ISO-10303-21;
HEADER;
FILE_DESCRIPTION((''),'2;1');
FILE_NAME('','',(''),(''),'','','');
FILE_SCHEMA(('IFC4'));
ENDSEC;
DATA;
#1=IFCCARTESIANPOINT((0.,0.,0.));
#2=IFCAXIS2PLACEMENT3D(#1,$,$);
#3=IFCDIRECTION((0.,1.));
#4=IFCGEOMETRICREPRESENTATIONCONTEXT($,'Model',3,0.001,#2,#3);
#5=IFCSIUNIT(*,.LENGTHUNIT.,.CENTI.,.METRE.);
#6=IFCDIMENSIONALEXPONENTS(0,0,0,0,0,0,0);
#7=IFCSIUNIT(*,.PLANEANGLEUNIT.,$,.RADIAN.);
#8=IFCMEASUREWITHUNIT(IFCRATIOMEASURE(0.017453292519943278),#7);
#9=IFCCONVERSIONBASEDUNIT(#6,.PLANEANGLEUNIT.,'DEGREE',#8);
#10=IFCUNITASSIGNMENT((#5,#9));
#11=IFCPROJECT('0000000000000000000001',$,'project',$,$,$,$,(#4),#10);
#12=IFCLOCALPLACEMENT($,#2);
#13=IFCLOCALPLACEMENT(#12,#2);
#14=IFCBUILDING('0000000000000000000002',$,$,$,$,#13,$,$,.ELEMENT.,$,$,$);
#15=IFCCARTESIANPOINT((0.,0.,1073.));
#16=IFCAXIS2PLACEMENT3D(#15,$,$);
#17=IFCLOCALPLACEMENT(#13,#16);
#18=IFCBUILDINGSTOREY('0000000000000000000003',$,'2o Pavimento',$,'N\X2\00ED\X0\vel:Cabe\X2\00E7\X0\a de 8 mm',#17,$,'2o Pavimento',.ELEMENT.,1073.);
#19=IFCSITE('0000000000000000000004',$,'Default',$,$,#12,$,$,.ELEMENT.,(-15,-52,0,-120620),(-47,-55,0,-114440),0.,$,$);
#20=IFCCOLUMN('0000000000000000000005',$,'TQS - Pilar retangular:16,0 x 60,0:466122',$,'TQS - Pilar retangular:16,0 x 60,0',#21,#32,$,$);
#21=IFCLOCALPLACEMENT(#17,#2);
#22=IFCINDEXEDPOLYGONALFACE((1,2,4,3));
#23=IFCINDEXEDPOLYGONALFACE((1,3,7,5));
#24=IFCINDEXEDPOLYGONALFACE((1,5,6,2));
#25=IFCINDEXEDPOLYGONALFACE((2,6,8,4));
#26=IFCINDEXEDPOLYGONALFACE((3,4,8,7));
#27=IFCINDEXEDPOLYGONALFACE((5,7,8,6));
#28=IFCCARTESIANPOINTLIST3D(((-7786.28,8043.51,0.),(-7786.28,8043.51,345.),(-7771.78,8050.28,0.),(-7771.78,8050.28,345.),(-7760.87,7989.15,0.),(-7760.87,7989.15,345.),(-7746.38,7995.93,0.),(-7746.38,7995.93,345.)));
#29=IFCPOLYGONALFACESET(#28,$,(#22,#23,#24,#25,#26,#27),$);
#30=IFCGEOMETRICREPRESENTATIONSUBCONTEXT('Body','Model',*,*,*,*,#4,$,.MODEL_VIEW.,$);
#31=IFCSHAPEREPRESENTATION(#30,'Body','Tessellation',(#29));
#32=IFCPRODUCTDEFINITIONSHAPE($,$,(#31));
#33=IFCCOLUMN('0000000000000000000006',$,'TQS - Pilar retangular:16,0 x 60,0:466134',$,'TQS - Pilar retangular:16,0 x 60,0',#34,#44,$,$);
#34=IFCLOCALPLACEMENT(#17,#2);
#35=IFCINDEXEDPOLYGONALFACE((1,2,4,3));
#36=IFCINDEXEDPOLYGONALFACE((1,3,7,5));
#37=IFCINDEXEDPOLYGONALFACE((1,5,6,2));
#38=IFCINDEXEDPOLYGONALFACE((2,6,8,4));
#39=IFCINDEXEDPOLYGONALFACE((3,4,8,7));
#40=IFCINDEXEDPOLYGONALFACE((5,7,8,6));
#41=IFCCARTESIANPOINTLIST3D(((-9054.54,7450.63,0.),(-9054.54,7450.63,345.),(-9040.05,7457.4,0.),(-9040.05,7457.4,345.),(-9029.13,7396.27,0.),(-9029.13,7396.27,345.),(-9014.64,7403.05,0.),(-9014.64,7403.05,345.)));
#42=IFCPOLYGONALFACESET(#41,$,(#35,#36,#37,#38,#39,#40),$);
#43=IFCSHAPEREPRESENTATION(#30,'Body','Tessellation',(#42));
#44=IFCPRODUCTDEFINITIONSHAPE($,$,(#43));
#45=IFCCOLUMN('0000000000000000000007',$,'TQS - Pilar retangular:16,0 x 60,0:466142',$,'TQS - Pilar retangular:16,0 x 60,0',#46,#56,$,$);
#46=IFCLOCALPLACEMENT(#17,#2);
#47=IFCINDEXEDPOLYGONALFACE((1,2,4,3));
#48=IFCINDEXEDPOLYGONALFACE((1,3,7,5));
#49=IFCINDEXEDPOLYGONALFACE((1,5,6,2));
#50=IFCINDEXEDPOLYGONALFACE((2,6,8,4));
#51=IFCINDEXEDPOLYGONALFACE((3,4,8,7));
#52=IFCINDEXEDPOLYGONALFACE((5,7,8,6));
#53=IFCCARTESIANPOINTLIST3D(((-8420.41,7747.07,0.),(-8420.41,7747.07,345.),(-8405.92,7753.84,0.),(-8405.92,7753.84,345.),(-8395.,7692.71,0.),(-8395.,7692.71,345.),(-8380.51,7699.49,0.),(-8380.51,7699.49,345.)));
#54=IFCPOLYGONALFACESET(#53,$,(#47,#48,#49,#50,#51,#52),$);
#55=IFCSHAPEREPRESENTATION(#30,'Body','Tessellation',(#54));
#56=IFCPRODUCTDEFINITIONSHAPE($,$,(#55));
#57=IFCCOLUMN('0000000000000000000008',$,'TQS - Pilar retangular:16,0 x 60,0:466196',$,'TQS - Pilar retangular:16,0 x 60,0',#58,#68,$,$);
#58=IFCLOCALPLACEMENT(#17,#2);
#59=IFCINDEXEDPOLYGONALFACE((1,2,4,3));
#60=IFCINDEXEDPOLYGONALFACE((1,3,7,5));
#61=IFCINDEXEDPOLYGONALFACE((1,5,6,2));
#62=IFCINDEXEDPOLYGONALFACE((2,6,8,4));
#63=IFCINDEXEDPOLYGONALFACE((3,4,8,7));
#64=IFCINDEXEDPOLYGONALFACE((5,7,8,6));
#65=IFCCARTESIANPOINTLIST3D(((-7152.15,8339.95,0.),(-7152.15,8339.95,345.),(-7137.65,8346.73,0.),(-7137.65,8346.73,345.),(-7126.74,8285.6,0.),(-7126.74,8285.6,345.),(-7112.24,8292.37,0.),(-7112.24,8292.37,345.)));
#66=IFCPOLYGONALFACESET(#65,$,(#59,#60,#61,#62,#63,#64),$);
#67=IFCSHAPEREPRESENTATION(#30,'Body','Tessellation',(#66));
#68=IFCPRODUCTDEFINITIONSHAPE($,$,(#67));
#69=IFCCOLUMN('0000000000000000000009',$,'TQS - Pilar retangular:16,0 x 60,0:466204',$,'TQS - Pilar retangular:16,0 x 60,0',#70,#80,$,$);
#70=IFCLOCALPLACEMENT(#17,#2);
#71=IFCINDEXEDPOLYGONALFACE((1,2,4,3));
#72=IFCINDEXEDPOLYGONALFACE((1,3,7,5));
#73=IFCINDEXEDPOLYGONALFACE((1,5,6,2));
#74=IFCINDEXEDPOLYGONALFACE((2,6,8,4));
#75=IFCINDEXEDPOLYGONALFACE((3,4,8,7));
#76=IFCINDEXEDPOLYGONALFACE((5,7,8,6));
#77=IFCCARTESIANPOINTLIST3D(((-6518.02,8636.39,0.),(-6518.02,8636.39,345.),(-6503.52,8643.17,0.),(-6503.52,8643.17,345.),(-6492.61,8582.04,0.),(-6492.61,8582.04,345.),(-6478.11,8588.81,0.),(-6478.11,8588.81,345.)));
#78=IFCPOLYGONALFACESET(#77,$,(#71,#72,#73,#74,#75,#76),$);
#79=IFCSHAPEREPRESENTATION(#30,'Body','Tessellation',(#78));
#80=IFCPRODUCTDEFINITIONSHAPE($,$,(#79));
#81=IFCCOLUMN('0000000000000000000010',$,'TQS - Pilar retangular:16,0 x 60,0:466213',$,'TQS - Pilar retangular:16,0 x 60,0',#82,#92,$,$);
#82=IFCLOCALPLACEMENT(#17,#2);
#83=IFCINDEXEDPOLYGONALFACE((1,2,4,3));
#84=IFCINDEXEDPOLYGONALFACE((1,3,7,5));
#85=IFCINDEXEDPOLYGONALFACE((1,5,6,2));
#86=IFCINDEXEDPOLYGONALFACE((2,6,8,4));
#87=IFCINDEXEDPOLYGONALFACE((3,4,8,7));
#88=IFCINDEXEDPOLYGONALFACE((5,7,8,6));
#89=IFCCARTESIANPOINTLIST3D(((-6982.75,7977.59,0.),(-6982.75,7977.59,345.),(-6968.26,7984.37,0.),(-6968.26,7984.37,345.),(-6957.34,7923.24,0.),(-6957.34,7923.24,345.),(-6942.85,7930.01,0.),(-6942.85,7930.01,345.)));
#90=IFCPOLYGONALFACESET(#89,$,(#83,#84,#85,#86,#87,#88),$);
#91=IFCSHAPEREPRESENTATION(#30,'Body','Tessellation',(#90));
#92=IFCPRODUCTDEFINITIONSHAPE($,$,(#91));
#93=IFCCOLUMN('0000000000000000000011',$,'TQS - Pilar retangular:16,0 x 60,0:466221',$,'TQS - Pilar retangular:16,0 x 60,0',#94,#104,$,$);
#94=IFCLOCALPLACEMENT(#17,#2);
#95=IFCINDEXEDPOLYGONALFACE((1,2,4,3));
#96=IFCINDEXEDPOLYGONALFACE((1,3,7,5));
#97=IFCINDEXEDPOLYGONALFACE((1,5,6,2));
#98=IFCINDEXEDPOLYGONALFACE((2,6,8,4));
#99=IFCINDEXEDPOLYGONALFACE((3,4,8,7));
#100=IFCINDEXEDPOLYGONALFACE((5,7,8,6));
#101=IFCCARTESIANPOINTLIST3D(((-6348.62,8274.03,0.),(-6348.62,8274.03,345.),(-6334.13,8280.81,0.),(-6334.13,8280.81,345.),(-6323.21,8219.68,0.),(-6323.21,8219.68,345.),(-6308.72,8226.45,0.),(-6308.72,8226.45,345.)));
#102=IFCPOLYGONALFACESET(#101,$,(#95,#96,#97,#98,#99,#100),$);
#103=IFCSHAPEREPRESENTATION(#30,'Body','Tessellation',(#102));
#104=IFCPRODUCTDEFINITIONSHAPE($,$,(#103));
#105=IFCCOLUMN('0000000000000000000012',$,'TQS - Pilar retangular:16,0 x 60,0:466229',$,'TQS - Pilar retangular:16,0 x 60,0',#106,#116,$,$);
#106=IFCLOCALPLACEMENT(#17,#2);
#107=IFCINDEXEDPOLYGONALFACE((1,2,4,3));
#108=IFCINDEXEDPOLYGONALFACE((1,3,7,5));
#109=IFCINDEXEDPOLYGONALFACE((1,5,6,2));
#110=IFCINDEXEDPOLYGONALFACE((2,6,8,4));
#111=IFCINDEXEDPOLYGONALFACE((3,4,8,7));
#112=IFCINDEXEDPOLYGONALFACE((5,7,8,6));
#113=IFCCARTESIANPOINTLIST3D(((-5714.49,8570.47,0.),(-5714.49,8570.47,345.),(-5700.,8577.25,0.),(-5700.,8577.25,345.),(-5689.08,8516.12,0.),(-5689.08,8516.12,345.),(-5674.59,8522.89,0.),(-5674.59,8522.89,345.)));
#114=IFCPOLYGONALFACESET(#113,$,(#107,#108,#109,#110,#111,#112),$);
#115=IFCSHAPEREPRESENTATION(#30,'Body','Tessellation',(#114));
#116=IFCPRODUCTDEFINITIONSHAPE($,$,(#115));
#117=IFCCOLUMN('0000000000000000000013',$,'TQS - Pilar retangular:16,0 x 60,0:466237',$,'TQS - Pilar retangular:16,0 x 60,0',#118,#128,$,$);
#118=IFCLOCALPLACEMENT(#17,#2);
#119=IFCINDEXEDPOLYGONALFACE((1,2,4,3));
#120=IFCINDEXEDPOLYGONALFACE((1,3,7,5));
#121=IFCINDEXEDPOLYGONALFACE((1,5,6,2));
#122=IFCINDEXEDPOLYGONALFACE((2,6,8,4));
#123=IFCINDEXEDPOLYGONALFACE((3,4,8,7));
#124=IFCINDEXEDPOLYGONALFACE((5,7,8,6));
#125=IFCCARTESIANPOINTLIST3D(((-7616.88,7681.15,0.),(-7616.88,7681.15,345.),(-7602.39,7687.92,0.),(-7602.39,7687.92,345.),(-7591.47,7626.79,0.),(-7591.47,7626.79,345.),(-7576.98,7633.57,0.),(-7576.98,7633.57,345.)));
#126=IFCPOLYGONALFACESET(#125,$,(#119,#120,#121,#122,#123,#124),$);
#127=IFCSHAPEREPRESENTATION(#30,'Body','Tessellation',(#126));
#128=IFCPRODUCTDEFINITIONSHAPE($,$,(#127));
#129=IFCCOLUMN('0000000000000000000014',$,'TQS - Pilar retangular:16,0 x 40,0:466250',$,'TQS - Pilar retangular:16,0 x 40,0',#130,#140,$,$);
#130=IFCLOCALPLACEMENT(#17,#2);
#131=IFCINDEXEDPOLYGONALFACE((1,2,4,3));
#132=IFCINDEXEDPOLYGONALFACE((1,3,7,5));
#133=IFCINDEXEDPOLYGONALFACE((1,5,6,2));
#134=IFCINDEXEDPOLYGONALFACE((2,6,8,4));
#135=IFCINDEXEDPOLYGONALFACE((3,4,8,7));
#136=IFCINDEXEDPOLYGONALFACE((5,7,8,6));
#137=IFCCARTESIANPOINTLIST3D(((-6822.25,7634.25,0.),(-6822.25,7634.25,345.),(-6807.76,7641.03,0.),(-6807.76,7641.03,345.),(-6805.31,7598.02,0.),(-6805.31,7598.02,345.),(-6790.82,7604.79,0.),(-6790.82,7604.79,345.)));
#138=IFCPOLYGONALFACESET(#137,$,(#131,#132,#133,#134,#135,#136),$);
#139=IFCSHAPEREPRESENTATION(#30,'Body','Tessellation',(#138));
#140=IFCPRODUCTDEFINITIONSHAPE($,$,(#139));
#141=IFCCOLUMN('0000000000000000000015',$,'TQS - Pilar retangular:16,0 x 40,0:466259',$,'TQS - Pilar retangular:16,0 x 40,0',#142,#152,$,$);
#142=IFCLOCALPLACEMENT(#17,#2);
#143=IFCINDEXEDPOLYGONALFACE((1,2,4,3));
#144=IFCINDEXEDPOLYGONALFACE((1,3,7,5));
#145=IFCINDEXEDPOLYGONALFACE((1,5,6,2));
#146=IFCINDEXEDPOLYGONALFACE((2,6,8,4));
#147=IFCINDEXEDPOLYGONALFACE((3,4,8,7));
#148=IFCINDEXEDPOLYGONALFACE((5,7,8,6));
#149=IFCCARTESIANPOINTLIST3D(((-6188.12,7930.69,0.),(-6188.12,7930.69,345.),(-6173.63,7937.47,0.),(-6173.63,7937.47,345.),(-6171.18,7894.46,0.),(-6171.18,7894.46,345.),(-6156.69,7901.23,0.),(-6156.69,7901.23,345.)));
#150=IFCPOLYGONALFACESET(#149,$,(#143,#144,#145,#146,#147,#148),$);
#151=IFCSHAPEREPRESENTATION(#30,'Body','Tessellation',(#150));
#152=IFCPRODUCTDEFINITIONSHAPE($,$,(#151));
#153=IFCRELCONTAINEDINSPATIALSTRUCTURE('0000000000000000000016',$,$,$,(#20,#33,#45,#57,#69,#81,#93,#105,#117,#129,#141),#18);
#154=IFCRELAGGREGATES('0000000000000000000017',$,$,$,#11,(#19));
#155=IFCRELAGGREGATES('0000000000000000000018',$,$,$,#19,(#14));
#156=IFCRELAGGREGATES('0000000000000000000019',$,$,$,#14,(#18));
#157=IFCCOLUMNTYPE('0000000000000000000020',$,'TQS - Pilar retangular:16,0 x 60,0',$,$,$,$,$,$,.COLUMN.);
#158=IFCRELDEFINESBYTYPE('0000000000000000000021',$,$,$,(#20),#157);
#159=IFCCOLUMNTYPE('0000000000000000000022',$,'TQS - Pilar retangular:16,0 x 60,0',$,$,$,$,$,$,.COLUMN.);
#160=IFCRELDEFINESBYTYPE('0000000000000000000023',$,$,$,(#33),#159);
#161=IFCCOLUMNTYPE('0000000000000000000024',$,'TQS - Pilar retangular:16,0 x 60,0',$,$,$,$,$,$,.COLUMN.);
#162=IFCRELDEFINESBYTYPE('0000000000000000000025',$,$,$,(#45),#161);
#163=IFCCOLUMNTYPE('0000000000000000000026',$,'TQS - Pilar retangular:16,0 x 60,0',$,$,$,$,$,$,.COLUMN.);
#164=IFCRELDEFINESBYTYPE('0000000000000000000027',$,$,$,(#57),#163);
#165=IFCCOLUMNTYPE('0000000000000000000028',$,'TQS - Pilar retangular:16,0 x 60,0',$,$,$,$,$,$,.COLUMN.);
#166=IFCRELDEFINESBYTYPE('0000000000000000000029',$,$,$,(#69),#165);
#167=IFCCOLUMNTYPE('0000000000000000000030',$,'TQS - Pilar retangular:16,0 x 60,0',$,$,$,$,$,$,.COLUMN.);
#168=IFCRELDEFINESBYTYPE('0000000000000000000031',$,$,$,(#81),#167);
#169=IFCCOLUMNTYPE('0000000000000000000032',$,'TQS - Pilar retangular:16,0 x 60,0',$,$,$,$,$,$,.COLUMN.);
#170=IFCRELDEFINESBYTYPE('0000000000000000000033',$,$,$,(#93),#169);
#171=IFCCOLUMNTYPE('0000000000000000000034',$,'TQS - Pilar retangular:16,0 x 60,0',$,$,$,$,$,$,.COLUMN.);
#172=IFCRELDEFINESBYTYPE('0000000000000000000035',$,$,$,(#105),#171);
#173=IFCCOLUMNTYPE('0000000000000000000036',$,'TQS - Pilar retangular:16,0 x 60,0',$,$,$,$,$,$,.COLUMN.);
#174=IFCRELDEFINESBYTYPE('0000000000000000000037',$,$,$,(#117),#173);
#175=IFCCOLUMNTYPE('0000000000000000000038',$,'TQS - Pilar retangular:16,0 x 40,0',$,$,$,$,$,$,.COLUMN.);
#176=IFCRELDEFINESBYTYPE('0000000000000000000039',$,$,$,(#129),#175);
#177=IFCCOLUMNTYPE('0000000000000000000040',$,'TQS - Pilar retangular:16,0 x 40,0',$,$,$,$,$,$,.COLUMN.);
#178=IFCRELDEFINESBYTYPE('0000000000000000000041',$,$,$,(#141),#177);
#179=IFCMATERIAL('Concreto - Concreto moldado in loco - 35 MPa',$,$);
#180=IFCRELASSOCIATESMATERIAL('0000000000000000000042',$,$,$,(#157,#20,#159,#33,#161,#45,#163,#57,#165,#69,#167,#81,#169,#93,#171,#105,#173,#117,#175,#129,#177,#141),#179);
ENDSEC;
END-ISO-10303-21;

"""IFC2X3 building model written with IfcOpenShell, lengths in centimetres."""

from ifc_helpers import new_model, entity, si_unit, converted_unit, direction, frame, frame_2d, origin, origin_2d_with_axis, place, context, subcontext, project, spatial, rectangle, extrude, source, transform, mapped, material, type_object, type_shapes, element, save


model = new_model("IFC2X3")

# Units and contexts
model_context = context("Model", 3, precision=0.001, world=origin(), true_north=direction((0.0, 1.0)))
body_context = subcontext(model_context, "Body", "Model", "MODEL_VIEW")
ifc_project = project(units=[si_unit("LENGTHUNIT", "METRE", prefix="CENTI"), converted_unit("PLANEANGLEUNIT", "DEGREE", entity("IfcRatioMeasure", 0.017453292519943278), si_unit("PLANEANGLEUNIT", "RADIAN"), dimensions=[0, 0, 0, 0, 0, 0, 0])], contexts=[model_context])

# Site, building, storey
site_placement = place(None, origin())
site = spatial("IfcSite", under=ifc_project, at=site_placement, Name="Default", CompositionType="ELEMENT", RefLatitude=(-15, -52, 0, -120620), RefLongitude=(-47, -55, 0, -114440), RefElevation=0.0)
building_placement = place(site_placement, origin())
building = spatial("IfcBuilding", under=site, at=building_placement, CompositionType="ELEMENT")
storey_placement = place(building_placement, frame((0.0, 0.0, 1073.0)))
storey = spatial("IfcBuildingStorey", under=building, at=storey_placement, Name="2o Pavimento", ObjectType="Nível:Cabeça de 8 mm", LongName="2o Pavimento", CompositionType="ELEMENT", Elevation=1073.0)

# Columns
ifc_material = material(Name="Concreto - Concreto moldado in loco - 35 MPa")
column_type_1 = type_object("IfcColumnType", Name="TQS - Pilar retangular:16,0 x 60,0", PredefinedType="COLUMN", material=ifc_material)
shared_shape_1 = source(origin(), body_context, "Body", "SweptSolid", [
    extrude(rectangle(XDim=60.0, YDim=16.0, at=origin_2d_with_axis()), frame((-7766.33, 8019.72, 1073.0), z_axis=(0.0, 0.0, 1.0), x_axis=(-0.423488, 0.905902, 0.0)), (0.0, 0.0, 1.0), 345.0),
])
type_shapes(column_type_1, [shared_shape_1])
column_1_placement = place(storey_placement, frame((0.0, 0.0, -1073.0)))
element("IfcColumn", 1, at=column_1_placement, inside=storey, type_object=column_type_1, material=ifc_material, Name="TQS - Pilar retangular:16,0 x 60,0:466122", ObjectType="TQS - Pilar retangular:16,0 x 60,0", context=body_context, shape_type="MappedRepresentation", body=[
    mapped(shared_shape_1, transform((0.0, 0.0, 0.0), scale=1.0)),
])
column_type_2 = type_object("IfcColumnType", Name="TQS - Pilar retangular:16,0 x 60,0", PredefinedType="COLUMN", material=ifc_material)
shared_shape_2 = source(origin(), body_context, "Body", "SweptSolid", [
    extrude(rectangle(XDim=60.0, YDim=16.0, at=origin_2d_with_axis()), frame((-9034.59, 7426.84, 1073.0), z_axis=(0.0, 0.0, 1.0), x_axis=(-0.423488, 0.905902, 0.0)), (0.0, 0.0, 1.0), 345.0),
])
type_shapes(column_type_2, [shared_shape_2])
column_2_placement = place(storey_placement, frame((0.0, 0.0, -1073.0)))
element("IfcColumn", 2, at=column_2_placement, inside=storey, type_object=column_type_2, material=ifc_material, Name="TQS - Pilar retangular:16,0 x 60,0:466134", ObjectType="TQS - Pilar retangular:16,0 x 60,0", context=body_context, shape_type="MappedRepresentation", body=[
    mapped(shared_shape_2, transform((0.0, 0.0, 0.0), scale=1.0)),
])
column_type_3 = type_object("IfcColumnType", Name="TQS - Pilar retangular:16,0 x 60,0", PredefinedType="COLUMN", material=ifc_material)
shared_shape_3 = source(origin(), body_context, "Body", "SweptSolid", [
    extrude(rectangle(XDim=60.0, YDim=16.0, at=origin_2d_with_axis()), frame((-8400.46, 7723.28, 1073.0), z_axis=(0.0, 0.0, 1.0), x_axis=(-0.423488, 0.905902, 0.0)), (0.0, 0.0, 1.0), 345.0),
])
type_shapes(column_type_3, [shared_shape_3])
column_3_placement = place(storey_placement, frame((0.0, 0.0, -1073.0)))
element("IfcColumn", 3, at=column_3_placement, inside=storey, type_object=column_type_3, material=ifc_material, Name="TQS - Pilar retangular:16,0 x 60,0:466142", ObjectType="TQS - Pilar retangular:16,0 x 60,0", context=body_context, shape_type="MappedRepresentation", body=[
    mapped(shared_shape_3, transform((0.0, 0.0, 0.0), scale=1.0)),
])
column_type_4 = type_object("IfcColumnType", Name="TQS - Pilar retangular:16,0 x 60,0", PredefinedType="COLUMN", material=ifc_material)
shared_shape_4 = source(origin(), body_context, "Body", "SweptSolid", [
    extrude(rectangle(XDim=60.0, YDim=16.0, at=origin_2d_with_axis()), frame((-7132.2, 8316.16, 1073.0), z_axis=(0.0, 0.0, 1.0), x_axis=(-0.423488, 0.905902, 0.0)), (0.0, 0.0, 1.0), 345.0),
])
type_shapes(column_type_4, [shared_shape_4])
column_4_placement = place(storey_placement, frame((0.0, 0.0, -1073.0)))
element("IfcColumn", 4, at=column_4_placement, inside=storey, type_object=column_type_4, material=ifc_material, Name="TQS - Pilar retangular:16,0 x 60,0:466196", ObjectType="TQS - Pilar retangular:16,0 x 60,0", context=body_context, shape_type="MappedRepresentation", body=[
    mapped(shared_shape_4, transform((0.0, 0.0, 0.0), scale=1.0)),
])
column_type_5 = type_object("IfcColumnType", Name="TQS - Pilar retangular:16,0 x 60,0", PredefinedType="COLUMN", material=ifc_material)
shared_shape_5 = source(origin(), body_context, "Body", "SweptSolid", [
    extrude(rectangle(XDim=60.0, YDim=16.0, at=origin_2d_with_axis()), frame((-6498.06, 8612.6, 1073.0), z_axis=(0.0, 0.0, 1.0), x_axis=(-0.423488, 0.905902, 0.0)), (0.0, 0.0, 1.0), 345.0),
])
type_shapes(column_type_5, [shared_shape_5])
column_5_placement = place(storey_placement, frame((0.0, 0.0, -1073.0)))
element("IfcColumn", 5, at=column_5_placement, inside=storey, type_object=column_type_5, material=ifc_material, Name="TQS - Pilar retangular:16,0 x 60,0:466204", ObjectType="TQS - Pilar retangular:16,0 x 60,0", context=body_context, shape_type="MappedRepresentation", body=[
    mapped(shared_shape_5, transform((0.0, 0.0, 0.0), scale=1.0)),
])
column_type_6 = type_object("IfcColumnType", Name="TQS - Pilar retangular:16,0 x 60,0", PredefinedType="COLUMN", material=ifc_material)
shared_shape_6 = source(origin(), body_context, "Body", "SweptSolid", [
    extrude(rectangle(XDim=60.0, YDim=16.0, at=frame_2d((0.0, 0.0), x_axis=(1.0, 0.0))), frame((-6962.8, 7953.8, 1073.0), z_axis=(0.0, 0.0, 1.0), x_axis=(-0.423488, 0.905902, 0.0)), (0.0, 0.0, 1.0), 345.0),
])
type_shapes(column_type_6, [shared_shape_6])
column_6_placement = place(storey_placement, frame((0.0, 0.0, -1073.0)))
element("IfcColumn", 6, at=column_6_placement, inside=storey, type_object=column_type_6, material=ifc_material, Name="TQS - Pilar retangular:16,0 x 60,0:466213", ObjectType="TQS - Pilar retangular:16,0 x 60,0", context=body_context, shape_type="MappedRepresentation", body=[
    mapped(shared_shape_6, transform((0.0, 0.0, 0.0), scale=1.0)),
])
column_type_7 = type_object("IfcColumnType", Name="TQS - Pilar retangular:16,0 x 60,0", PredefinedType="COLUMN", material=ifc_material)
shared_shape_7 = source(origin(), body_context, "Body", "SweptSolid", [
    extrude(rectangle(XDim=60.0, YDim=16.0, at=origin_2d_with_axis()), frame((-6328.67, 8250.24, 1073.0), z_axis=(0.0, 0.0, 1.0), x_axis=(-0.423488, 0.905902, 0.0)), (0.0, 0.0, 1.0), 345.0),
])
type_shapes(column_type_7, [shared_shape_7])
column_7_placement = place(storey_placement, frame((0.0, 0.0, -1073.0)))
element("IfcColumn", 7, at=column_7_placement, inside=storey, type_object=column_type_7, material=ifc_material, Name="TQS - Pilar retangular:16,0 x 60,0:466221", ObjectType="TQS - Pilar retangular:16,0 x 60,0", context=body_context, shape_type="MappedRepresentation", body=[
    mapped(shared_shape_7, transform((0.0, 0.0, 0.0), scale=1.0)),
])
column_type_8 = type_object("IfcColumnType", Name="TQS - Pilar retangular:16,0 x 60,0", PredefinedType="COLUMN", material=ifc_material)
shared_shape_8 = source(origin(), body_context, "Body", "SweptSolid", [
    extrude(rectangle(XDim=60.0, YDim=16.0, at=frame_2d((0.0, 0.0), x_axis=(1.0, 0.0))), frame((-5694.54, 8546.68, 1073.0), z_axis=(0.0, 0.0, 1.0), x_axis=(-0.423488, 0.905902, 0.0)), (0.0, 0.0, 1.0), 345.0),
])
type_shapes(column_type_8, [shared_shape_8])
column_8_placement = place(storey_placement, frame((0.0, 0.0, -1073.0)))
element("IfcColumn", 8, at=column_8_placement, inside=storey, type_object=column_type_8, material=ifc_material, Name="TQS - Pilar retangular:16,0 x 60,0:466229", ObjectType="TQS - Pilar retangular:16,0 x 60,0", context=body_context, shape_type="MappedRepresentation", body=[
    mapped(shared_shape_8, transform((0.0, 0.0, 0.0), scale=1.0)),
])
column_type_9 = type_object("IfcColumnType", Name="TQS - Pilar retangular:16,0 x 60,0", PredefinedType="COLUMN", material=ifc_material)
shared_shape_9 = source(origin(), body_context, "Body", "SweptSolid", [
    extrude(rectangle(XDim=60.0, YDim=16.0, at=frame_2d((0.0, 0.0), x_axis=(1.0, 0.0))), frame((-7596.93, 7657.36, 1073.0), z_axis=(0.0, 0.0, 1.0), x_axis=(-0.423488, 0.905902, 0.0)), (0.0, 0.0, 1.0), 345.0),
])
type_shapes(column_type_9, [shared_shape_9])
column_9_placement = place(storey_placement, frame((0.0, 0.0, -1073.0)))
element("IfcColumn", 9, at=column_9_placement, inside=storey, type_object=column_type_9, material=ifc_material, Name="TQS - Pilar retangular:16,0 x 60,0:466237", ObjectType="TQS - Pilar retangular:16,0 x 60,0", context=body_context, shape_type="MappedRepresentation", body=[
    mapped(shared_shape_9, transform((0.0, 0.0, 0.0), scale=1.0)),
])
column_type_10 = type_object("IfcColumnType", Name="TQS - Pilar retangular:16,0 x 40,0", PredefinedType="COLUMN", material=ifc_material)
shared_shape_10 = source(origin(), body_context, "Body", "SweptSolid", [
    extrude(rectangle(XDim=40.0, YDim=16.0, at=origin_2d_with_axis()), frame((-6806.53, 7619.52, 1073.0), z_axis=(0.0, 0.0, 1.0), x_axis=(-0.423488, 0.905902, 0.0)), (0.0, 0.0, 1.0), 345.0),
])
type_shapes(column_type_10, [shared_shape_10])
column_10_placement = place(storey_placement, frame((0.0, 0.0, -1073.0)))
element("IfcColumn", 10, at=column_10_placement, inside=storey, type_object=column_type_10, material=ifc_material, Name="TQS - Pilar retangular:16,0 x 40,0:466250", ObjectType="TQS - Pilar retangular:16,0 x 40,0", context=body_context, shape_type="MappedRepresentation", body=[
    mapped(shared_shape_10, transform((0.0, 0.0, 0.0), scale=1.0)),
])
column_type_11 = type_object("IfcColumnType", Name="TQS - Pilar retangular:16,0 x 40,0", PredefinedType="COLUMN", material=ifc_material)
shared_shape_11 = source(origin(), body_context, "Body", "SweptSolid", [
    extrude(rectangle(XDim=40.0, YDim=16.0, at=origin_2d_with_axis()), frame((-6172.4, 7915.96, 1073.0), z_axis=(0.0, 0.0, 1.0), x_axis=(-0.423488, 0.905902, 0.0)), (0.0, 0.0, 1.0), 345.0),
])
type_shapes(column_type_11, [shared_shape_11])
column_11_placement = place(storey_placement, frame((0.0, 0.0, -1073.0)))
element("IfcColumn", 11, at=column_11_placement, inside=storey, type_object=column_type_11, material=ifc_material, Name="TQS - Pilar retangular:16,0 x 40,0:466259", ObjectType="TQS - Pilar retangular:16,0 x 40,0", context=body_context, shape_type="MappedRepresentation", body=[
    mapped(shared_shape_11, transform((0.0, 0.0, 0.0), scale=1.0)),
])

save(model, "model.ifc")
